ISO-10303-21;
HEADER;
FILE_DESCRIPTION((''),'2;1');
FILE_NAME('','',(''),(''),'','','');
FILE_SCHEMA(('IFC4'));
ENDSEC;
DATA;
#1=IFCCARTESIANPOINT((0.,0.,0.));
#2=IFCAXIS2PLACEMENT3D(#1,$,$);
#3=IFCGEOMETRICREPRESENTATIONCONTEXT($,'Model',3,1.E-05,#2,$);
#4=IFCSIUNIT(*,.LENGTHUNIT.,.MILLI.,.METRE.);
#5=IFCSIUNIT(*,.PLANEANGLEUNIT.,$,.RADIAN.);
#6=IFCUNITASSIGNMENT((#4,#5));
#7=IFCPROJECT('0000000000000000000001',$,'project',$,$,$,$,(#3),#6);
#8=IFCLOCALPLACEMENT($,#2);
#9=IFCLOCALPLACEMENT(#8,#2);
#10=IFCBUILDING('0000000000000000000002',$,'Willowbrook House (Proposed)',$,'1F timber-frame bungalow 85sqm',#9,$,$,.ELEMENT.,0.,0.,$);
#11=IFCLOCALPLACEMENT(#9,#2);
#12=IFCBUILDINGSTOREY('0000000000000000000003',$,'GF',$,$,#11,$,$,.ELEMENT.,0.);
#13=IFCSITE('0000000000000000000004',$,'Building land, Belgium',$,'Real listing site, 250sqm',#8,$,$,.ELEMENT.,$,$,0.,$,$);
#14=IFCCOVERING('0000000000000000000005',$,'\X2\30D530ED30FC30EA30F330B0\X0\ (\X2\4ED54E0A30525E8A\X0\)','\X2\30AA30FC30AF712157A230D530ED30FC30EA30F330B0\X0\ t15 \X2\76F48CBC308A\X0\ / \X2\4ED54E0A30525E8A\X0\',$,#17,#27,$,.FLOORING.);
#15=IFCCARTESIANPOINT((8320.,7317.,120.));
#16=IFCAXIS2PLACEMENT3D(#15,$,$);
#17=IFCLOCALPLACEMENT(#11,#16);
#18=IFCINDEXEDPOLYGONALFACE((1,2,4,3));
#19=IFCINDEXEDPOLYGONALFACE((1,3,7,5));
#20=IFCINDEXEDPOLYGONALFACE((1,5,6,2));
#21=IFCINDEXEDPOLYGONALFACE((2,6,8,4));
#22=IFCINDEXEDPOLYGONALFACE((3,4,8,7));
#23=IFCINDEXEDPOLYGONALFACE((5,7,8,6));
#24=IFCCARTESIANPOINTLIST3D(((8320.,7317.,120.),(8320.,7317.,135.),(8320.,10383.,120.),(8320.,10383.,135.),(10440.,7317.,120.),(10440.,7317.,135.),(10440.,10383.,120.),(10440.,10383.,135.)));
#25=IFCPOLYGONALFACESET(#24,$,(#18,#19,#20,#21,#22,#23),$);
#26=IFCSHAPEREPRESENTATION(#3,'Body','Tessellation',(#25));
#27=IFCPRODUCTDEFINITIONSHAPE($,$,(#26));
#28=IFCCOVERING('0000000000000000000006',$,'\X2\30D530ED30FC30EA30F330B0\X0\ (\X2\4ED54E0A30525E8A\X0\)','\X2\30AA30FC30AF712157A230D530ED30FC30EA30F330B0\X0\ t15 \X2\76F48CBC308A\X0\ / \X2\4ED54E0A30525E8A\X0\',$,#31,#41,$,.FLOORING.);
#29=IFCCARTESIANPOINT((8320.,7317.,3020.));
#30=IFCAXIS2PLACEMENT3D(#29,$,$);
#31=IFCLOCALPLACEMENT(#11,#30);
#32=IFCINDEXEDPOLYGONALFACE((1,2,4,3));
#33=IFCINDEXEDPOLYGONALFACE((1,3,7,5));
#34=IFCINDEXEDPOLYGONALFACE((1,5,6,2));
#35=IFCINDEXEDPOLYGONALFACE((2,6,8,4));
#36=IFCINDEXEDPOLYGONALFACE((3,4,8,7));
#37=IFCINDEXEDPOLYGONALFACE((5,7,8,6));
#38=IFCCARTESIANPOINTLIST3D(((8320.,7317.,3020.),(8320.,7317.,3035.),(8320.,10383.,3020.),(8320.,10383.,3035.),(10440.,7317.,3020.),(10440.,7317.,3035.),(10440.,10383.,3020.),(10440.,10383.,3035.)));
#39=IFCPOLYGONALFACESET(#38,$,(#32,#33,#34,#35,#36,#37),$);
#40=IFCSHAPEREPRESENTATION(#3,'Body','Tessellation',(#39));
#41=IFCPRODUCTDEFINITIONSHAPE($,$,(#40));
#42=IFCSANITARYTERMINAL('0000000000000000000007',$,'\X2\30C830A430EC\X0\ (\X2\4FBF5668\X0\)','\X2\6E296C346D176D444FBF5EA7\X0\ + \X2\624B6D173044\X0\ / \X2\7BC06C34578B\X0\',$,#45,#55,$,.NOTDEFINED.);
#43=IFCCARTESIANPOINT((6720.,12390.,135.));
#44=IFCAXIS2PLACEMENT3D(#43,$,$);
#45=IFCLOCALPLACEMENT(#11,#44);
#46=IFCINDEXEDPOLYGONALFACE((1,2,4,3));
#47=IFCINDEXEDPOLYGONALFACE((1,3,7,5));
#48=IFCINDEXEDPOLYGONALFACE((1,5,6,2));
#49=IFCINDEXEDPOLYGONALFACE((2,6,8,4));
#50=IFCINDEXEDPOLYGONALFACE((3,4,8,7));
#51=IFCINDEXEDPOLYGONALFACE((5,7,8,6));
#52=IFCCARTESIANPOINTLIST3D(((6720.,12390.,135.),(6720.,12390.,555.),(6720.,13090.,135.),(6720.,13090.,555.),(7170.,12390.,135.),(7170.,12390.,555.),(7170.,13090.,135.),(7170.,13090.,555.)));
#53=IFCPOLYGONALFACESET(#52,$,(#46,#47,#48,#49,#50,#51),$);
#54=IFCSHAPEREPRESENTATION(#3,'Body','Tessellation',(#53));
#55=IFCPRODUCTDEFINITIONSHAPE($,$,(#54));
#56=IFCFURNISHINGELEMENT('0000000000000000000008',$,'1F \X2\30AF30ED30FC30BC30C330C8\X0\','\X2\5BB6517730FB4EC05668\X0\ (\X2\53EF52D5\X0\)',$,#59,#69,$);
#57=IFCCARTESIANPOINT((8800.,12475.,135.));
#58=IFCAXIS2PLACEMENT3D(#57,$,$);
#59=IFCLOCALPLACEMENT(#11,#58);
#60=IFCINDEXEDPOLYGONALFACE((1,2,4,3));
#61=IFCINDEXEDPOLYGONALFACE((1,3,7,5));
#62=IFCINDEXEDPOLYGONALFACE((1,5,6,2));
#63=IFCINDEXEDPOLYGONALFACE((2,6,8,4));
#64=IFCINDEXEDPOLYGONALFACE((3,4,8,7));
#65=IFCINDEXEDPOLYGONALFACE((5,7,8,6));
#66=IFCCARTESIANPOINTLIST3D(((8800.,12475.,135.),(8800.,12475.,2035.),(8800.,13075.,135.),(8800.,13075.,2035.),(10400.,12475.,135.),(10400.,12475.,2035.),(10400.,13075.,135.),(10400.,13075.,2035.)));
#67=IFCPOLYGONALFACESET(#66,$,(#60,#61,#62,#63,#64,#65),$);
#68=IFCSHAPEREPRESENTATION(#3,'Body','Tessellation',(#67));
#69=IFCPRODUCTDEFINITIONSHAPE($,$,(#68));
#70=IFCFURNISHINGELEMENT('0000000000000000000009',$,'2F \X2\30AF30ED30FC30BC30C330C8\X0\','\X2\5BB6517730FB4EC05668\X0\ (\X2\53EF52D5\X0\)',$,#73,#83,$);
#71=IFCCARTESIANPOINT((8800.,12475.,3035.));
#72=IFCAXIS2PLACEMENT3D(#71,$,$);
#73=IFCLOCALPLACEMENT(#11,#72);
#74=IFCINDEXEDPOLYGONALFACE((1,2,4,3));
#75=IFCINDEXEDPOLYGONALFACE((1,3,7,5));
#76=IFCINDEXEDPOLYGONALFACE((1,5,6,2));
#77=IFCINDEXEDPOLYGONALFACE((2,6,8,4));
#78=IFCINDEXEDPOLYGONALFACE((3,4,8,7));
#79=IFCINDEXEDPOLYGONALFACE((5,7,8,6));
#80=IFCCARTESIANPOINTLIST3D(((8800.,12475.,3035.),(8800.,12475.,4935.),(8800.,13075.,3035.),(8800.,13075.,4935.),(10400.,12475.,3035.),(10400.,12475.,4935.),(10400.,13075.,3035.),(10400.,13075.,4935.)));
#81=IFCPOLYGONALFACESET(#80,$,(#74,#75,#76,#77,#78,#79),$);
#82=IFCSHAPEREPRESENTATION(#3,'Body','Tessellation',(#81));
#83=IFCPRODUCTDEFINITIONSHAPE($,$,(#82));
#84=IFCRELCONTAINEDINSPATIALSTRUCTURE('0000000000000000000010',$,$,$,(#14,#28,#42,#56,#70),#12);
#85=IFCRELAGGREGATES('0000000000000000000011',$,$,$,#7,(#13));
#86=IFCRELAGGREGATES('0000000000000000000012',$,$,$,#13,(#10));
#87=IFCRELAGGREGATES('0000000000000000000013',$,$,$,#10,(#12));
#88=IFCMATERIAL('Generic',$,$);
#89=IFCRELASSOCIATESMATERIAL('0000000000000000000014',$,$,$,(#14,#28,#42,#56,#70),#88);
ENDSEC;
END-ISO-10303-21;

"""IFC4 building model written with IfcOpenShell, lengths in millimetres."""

from ifc_helpers import new_model, si_unit, frame, frame_2d, origin, place, context, project, spatial, rectangle, extrude, material, element, save


model = new_model("IFC4")

# Units and contexts
model_context = context("Model", 3, precision=1e-05, world=origin())
ifc_project = project(units=[si_unit("LENGTHUNIT", "METRE", prefix="MILLI"), si_unit("PLANEANGLEUNIT", "RADIAN")], contexts=[model_context])

# Site, building, storey
site_placement = place(None, origin())
site = spatial("IfcSite", under=ifc_project, at=site_placement, Name="Building land, Belgium", ObjectType="Real listing site, 250sqm", CompositionType="ELEMENT", RefElevation=0.0)
building_placement = place(site_placement, origin())
building = spatial("IfcBuilding", under=site, at=building_placement, Name="Willowbrook House (Proposed)", ObjectType="1F timber-frame bungalow 85sqm", CompositionType="ELEMENT", ElevationOfRefHeight=0.0, ElevationOfTerrain=0.0)
storey_placement = place(building_placement, origin())
storey = spatial("IfcBuildingStorey", under=building, at=storey_placement, Name="GF", CompositionType="ELEMENT", Elevation=0.0)

# Shared definitions
ifc_material_1 = material(Name="Generic")

# Coverings
covering_1_placement = place(storey_placement, frame((8320.0, 7317.0, 120.0)))
element("IfcCovering", 1, at=covering_1_placement, inside=storey, material=ifc_material_1, Name="フローリング (仕上げ床)", Description="オーク無垢フローリング t15 直貼り / 仕上げ床", PredefinedType="FLOORING", context=model_context, shape_type="SweptSolid", body=[
    extrude(rectangle(XDim=2120.0, YDim=3066.0, at=frame_2d((1060.0, 1533.0))), frame((8320.0, 7317.0, 120.0)), (0.0, 0.0, 1.0), 15.0),
])
covering_2_placement = place(storey_placement, frame((8320.0, 7317.0, 3020.0)))
element("IfcCovering", 2, at=covering_2_placement, inside=storey, material=ifc_material_1, Name="フローリング (仕上げ床)", Description="オーク無垢フローリング t15 直貼り / 仕上げ床", PredefinedType="FLOORING", context=model_context, shape_type="SweptSolid", body=[
    extrude(rectangle(XDim=2120.0, YDim=3066.0, at=frame_2d((1060.0, 1533.0))), frame((8320.0, 7317.0, 3020.0)), (0.0, 0.0, 1.0), 15.0),
])

# Sanitary terminal
sanitary_terminal_placement = place(storey_placement, frame((6720.0, 12390.0, 135.0)))
element("IfcSanitaryTerminal", 3, at=sanitary_terminal_placement, inside=storey, material=ifc_material_1, Name="トイレ (便器)", Description="温水洗浄便座 + 手洗い / 節水型", PredefinedType="NOTDEFINED", context=model_context, shape_type="SweptSolid", body=[
    extrude(rectangle(XDim=450.0, YDim=700.0, at=frame_2d((225.0, 350.0))), frame((6720.0, 12390.0, 135.0)), (0.0, 0.0, 1.0), 420.0),
])

# Furnishing elements
furnishing_1_placement = place(storey_placement, frame((8800.0, 12475.0, 135.0)))
element("IfcFurnishingElement", 4, at=furnishing_1_placement, inside=storey, material=ifc_material_1, Name="1F クローゼット", Description="家具・什器 (可動)", context=model_context, shape_type="SweptSolid", body=[
    extrude(rectangle(XDim=1600.0, YDim=600.0, at=frame_2d((800.0, 300.0))), frame((8800.0, 12475.0, 135.0)), (0.0, 0.0, 1.0), 1900.0),
])
furnishing_2_placement = place(storey_placement, frame((8800.0, 12475.0, 3035.0)))
element("IfcFurnishingElement", 5, at=furnishing_2_placement, inside=storey, material=ifc_material_1, Name="2F クローゼット", Description="家具・什器 (可動)", context=model_context, shape_type="SweptSolid", body=[
    extrude(rectangle(XDim=1600.0, YDim=600.0, at=frame_2d((800.0, 300.0))), frame((8800.0, 12475.0, 3035.0)), (0.0, 0.0, 1.0), 1900.0),
])

save(model, "model.ifc")
